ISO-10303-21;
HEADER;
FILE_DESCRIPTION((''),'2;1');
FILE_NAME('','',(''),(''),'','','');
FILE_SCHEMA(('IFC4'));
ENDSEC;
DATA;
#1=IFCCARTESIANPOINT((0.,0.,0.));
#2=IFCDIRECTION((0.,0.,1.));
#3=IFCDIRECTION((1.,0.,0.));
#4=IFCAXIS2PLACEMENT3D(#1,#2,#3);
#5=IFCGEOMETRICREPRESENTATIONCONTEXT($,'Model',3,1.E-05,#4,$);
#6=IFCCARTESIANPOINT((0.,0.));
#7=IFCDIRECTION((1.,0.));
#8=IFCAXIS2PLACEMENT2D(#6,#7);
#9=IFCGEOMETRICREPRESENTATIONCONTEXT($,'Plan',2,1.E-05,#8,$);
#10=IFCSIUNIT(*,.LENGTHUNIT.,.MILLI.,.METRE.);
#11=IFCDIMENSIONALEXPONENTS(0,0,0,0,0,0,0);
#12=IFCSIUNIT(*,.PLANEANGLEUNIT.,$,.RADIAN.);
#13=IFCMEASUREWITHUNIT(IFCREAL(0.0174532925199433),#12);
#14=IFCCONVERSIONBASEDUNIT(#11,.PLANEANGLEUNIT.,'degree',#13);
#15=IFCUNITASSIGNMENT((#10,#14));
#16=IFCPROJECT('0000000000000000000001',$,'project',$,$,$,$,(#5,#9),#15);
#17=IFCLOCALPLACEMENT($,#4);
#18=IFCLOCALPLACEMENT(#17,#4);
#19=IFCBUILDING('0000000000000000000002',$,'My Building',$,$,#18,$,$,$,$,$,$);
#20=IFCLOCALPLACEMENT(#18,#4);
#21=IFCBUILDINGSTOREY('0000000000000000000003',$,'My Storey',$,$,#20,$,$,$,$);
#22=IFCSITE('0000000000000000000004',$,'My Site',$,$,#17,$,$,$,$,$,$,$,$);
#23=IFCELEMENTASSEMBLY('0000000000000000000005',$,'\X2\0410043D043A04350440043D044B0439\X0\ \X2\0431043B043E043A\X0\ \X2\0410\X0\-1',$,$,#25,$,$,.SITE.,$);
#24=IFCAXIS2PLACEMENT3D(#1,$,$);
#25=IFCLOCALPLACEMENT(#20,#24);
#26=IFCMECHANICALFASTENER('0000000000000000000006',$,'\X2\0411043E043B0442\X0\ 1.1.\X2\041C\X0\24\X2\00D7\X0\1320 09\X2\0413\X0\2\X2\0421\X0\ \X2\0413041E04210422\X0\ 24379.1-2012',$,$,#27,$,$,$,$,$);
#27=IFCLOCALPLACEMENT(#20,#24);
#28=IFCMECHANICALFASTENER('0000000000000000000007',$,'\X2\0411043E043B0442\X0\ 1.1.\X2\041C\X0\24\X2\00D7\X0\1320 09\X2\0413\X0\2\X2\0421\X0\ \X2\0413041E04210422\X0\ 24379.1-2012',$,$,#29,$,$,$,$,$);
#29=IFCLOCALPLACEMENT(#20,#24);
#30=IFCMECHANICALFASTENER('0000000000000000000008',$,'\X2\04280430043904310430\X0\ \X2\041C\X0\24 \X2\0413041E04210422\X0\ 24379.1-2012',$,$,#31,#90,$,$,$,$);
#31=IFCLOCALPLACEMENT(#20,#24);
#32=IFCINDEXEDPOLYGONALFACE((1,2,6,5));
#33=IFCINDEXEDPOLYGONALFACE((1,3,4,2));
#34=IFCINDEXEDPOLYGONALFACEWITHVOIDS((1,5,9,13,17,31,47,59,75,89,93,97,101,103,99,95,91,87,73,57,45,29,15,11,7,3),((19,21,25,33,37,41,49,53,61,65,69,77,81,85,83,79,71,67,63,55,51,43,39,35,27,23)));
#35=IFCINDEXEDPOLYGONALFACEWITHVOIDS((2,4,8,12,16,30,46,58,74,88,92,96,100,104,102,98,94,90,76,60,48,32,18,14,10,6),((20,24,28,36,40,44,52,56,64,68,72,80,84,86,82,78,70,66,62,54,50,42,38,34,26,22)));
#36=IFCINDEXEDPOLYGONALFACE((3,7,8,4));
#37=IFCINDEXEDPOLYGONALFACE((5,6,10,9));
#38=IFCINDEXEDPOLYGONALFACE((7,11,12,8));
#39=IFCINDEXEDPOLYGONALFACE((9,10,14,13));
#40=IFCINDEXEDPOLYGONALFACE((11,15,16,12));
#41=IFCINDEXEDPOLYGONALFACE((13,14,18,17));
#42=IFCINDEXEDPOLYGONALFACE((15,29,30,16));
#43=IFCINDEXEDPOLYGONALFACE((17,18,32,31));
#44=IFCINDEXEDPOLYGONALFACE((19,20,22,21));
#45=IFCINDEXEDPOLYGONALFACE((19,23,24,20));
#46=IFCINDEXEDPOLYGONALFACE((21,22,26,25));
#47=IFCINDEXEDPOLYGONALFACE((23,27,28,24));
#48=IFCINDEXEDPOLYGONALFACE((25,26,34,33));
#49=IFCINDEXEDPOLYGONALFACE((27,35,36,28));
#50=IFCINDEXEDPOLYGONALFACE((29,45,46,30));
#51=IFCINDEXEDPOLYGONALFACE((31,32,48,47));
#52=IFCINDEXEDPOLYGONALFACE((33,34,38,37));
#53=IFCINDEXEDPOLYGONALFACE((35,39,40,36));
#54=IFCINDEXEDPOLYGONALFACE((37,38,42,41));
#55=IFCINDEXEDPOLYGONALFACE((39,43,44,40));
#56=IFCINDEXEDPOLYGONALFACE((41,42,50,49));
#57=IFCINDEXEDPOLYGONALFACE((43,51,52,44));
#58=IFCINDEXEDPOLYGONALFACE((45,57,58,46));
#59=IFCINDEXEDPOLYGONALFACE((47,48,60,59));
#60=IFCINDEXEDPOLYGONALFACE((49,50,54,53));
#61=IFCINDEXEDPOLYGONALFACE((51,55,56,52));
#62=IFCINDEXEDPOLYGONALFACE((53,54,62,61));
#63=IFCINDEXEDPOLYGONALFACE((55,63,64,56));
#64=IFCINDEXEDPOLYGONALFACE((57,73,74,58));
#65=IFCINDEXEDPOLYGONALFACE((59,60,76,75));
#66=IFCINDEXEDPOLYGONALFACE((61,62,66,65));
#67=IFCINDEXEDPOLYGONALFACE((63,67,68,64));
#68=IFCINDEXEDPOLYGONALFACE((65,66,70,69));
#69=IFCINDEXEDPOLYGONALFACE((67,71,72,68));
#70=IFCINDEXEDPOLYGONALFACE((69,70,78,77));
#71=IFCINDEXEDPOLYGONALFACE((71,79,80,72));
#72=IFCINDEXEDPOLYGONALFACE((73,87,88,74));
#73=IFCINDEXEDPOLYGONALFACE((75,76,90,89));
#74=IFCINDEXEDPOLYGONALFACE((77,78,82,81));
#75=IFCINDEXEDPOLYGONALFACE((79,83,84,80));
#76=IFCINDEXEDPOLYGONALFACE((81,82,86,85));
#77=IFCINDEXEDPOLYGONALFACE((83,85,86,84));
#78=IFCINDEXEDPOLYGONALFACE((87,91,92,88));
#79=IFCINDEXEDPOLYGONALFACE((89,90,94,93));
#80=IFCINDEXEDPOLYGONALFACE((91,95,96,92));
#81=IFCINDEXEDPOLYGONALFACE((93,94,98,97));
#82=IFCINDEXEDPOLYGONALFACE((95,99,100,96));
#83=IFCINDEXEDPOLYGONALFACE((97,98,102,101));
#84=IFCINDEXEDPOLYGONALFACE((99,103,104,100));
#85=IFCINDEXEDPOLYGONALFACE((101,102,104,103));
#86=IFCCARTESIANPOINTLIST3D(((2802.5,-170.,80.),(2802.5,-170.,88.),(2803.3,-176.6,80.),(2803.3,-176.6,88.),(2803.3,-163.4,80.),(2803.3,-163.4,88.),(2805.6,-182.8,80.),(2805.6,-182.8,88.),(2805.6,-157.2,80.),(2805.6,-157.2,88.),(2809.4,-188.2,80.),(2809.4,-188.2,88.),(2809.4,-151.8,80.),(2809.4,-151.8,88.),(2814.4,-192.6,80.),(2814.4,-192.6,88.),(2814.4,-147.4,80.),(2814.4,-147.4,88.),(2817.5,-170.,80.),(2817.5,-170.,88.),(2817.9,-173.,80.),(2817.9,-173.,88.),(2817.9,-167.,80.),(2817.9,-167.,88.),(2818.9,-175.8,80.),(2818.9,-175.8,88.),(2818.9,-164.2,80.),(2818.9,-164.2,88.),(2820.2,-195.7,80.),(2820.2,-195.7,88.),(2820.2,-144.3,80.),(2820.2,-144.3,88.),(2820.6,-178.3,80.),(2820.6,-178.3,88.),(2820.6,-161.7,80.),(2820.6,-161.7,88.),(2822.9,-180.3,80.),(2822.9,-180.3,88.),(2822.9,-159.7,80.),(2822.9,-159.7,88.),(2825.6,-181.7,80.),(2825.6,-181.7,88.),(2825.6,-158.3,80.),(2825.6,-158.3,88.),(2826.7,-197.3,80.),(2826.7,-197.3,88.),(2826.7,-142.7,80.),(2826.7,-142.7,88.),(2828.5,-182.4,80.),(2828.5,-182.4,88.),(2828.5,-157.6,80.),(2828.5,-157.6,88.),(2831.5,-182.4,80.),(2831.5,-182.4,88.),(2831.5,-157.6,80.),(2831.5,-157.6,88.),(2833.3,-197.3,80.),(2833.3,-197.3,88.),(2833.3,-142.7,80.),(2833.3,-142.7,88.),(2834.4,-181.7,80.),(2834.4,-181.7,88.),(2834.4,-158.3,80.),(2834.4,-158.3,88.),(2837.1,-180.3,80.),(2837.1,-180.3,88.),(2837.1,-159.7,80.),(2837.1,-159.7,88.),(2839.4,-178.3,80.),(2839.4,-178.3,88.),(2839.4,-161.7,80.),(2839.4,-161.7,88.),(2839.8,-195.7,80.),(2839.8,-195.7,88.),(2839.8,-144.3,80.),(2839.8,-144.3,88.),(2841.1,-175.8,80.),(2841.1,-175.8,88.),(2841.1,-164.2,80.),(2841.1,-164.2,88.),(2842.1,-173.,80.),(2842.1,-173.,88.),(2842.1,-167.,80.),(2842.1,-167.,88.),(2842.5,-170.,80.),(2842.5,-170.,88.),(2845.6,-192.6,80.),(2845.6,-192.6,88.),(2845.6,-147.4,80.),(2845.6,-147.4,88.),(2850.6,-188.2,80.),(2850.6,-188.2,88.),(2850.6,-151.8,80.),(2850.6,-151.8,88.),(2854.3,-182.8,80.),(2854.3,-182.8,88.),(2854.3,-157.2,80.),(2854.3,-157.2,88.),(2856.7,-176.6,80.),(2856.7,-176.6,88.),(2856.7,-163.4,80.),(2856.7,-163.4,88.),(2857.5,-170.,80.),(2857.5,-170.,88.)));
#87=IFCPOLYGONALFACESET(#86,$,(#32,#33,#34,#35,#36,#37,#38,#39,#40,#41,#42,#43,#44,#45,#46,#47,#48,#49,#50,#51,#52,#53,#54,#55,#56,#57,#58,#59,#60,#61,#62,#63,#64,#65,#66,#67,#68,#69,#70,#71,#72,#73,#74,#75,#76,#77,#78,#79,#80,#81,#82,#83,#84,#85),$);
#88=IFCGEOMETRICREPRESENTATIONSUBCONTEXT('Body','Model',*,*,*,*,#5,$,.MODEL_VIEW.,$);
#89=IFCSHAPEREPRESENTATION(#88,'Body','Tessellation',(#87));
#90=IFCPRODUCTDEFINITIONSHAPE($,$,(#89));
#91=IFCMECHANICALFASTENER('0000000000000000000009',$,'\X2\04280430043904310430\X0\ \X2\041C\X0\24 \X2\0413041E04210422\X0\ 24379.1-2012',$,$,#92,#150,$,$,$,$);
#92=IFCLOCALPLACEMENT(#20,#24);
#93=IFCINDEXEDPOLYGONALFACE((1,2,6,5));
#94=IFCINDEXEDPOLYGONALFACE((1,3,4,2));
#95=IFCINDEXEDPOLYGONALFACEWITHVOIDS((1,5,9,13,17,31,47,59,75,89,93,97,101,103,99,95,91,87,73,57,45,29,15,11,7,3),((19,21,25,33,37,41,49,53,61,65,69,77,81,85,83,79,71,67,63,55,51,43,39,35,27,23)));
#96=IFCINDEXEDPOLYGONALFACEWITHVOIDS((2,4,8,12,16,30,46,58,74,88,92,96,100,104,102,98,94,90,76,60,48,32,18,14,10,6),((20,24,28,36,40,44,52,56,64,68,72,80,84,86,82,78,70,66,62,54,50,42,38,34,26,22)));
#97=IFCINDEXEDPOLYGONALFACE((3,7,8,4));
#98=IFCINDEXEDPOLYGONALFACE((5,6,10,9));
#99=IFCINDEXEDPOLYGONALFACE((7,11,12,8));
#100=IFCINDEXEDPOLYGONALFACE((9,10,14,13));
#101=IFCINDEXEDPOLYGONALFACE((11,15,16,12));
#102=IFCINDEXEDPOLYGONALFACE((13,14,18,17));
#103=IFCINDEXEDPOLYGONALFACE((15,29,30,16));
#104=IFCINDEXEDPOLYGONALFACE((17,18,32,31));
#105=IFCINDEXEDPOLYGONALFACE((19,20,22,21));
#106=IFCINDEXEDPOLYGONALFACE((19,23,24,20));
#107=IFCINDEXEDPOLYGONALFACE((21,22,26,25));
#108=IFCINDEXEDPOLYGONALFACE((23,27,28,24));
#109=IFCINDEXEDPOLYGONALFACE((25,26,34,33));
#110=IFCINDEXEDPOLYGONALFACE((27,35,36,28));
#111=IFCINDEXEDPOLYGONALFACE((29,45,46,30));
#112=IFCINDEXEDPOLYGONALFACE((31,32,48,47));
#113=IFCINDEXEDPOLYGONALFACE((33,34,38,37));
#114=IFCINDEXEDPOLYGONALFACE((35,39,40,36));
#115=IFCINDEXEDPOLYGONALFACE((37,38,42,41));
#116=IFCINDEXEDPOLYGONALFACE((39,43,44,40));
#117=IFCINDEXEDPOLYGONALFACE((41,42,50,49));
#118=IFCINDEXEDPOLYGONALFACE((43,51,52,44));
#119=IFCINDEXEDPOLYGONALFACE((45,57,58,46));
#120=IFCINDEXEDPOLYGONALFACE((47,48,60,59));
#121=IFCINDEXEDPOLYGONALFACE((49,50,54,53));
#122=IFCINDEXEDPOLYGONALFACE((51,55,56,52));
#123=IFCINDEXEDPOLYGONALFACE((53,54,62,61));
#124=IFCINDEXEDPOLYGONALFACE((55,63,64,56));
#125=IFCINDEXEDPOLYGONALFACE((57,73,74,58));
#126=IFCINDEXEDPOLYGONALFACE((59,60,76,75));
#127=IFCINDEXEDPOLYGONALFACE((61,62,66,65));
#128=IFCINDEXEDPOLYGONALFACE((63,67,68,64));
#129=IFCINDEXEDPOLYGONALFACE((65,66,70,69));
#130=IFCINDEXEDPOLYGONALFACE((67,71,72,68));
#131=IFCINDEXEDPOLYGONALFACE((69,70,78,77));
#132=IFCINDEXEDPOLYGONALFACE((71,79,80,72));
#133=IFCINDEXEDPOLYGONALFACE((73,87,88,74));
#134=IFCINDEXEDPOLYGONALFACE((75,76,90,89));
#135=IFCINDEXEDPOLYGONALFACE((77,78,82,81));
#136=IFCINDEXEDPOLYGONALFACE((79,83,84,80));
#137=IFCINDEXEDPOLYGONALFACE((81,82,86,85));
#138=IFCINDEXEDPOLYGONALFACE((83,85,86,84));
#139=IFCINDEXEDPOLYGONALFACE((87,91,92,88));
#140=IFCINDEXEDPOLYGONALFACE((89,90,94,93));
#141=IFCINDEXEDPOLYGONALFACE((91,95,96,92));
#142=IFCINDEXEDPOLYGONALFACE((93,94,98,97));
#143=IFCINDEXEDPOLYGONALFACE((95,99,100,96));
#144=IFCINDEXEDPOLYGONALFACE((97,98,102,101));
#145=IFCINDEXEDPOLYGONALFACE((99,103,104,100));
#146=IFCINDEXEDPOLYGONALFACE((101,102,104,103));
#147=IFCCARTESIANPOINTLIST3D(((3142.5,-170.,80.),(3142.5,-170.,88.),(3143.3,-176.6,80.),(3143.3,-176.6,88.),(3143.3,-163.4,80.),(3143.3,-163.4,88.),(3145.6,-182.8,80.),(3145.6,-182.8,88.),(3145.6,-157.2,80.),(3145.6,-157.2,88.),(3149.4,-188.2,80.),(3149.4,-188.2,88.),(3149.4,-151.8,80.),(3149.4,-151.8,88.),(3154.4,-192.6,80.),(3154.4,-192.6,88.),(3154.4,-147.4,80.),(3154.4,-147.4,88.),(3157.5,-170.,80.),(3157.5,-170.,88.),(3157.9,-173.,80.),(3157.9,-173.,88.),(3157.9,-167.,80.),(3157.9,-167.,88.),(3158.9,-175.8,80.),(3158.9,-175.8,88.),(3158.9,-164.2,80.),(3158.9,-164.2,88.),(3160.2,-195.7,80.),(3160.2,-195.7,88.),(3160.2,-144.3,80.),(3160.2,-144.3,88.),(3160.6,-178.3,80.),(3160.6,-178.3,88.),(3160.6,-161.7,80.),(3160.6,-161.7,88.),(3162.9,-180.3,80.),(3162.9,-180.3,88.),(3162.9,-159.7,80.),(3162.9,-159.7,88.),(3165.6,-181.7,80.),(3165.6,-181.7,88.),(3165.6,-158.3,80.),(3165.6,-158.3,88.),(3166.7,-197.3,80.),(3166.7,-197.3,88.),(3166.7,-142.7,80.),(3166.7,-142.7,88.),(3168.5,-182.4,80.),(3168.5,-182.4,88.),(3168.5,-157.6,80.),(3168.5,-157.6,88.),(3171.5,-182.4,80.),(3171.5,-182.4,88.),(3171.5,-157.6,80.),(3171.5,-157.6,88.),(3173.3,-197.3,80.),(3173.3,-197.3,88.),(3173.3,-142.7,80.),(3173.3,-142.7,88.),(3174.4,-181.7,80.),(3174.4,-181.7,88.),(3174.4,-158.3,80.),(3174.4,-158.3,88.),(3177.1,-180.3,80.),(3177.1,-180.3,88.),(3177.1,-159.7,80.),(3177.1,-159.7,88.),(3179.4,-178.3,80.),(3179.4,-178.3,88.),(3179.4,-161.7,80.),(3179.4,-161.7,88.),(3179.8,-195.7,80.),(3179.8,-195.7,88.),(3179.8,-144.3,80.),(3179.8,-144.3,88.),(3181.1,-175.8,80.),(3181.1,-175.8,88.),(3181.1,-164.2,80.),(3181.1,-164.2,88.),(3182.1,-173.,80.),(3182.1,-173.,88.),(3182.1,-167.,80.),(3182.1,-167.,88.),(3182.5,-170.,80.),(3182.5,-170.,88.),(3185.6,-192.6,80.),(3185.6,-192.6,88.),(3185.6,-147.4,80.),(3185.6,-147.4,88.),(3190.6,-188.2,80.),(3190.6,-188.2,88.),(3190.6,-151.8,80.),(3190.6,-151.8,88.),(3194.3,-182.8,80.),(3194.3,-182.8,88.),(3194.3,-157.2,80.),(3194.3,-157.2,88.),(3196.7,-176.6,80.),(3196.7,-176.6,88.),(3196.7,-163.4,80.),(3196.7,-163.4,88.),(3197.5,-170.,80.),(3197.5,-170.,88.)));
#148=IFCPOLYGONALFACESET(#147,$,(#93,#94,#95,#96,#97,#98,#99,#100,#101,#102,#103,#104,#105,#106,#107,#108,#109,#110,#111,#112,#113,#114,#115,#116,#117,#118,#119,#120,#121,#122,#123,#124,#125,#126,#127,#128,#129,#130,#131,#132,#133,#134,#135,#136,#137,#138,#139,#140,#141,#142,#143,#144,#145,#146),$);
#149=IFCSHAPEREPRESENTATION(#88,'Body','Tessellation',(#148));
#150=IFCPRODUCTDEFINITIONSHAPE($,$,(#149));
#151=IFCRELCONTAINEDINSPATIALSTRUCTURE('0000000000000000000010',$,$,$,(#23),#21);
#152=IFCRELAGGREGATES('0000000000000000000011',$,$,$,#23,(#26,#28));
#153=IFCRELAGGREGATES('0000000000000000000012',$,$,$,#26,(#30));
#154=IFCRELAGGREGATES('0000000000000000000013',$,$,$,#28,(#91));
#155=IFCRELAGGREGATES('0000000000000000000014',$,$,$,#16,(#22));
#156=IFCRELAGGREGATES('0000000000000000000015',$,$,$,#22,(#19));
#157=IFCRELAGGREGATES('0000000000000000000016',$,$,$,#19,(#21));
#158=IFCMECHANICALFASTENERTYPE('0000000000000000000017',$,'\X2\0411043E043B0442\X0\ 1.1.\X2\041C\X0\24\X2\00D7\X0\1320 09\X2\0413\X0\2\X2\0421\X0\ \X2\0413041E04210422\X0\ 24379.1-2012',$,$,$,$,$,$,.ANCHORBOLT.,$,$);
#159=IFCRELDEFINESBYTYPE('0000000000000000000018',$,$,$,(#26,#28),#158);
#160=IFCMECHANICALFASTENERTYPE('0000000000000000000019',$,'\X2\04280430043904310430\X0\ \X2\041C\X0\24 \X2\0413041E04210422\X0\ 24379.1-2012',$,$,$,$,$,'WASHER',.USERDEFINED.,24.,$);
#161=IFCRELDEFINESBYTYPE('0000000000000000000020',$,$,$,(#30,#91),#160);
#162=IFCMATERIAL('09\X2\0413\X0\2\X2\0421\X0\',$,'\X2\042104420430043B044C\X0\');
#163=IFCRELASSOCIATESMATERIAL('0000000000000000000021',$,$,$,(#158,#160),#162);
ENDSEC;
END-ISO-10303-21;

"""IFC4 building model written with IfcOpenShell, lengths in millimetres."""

from ifc_helpers import new_model, entity, si_unit, converted_unit, frame, origin_with_axes, origin_2d_with_axis, place, context, subcontext, project, spatial, polyline, outline, extrude, source, transform, mapped, material, type_object, type_shapes, element, aggregate, save


model = new_model("IFC4")

# Units and contexts
model_context = context("Model", 3, precision=1e-05, world=origin_with_axes())
plan_context = context("Plan", 2, precision=1e-05, world=origin_2d_with_axis())
body_context = subcontext(model_context, "Body", "Model", "MODEL_VIEW")
ifc_project = project(units=[si_unit("LENGTHUNIT", "METRE", prefix="MILLI"), converted_unit("PLANEANGLEUNIT", "degree", entity("IfcReal", 0.0174532925199433), si_unit("PLANEANGLEUNIT", "RADIAN"), dimensions=[0, 0, 0, 0, 0, 0, 0])], contexts=[model_context, plan_context])

# Site, building, storey
site_placement = place(None, origin_with_axes())
site = spatial("IfcSite", under=ifc_project, at=site_placement, Name="My Site")
building_placement = place(site_placement, origin_with_axes())
building = spatial("IfcBuilding", under=site, at=building_placement, Name="My Building")
storey_placement = place(building_placement, origin_with_axes())
storey = spatial("IfcBuildingStorey", under=building, at=storey_placement, Name="My Storey")

# Element assembly
placement_1 = place(storey_placement, frame((3000.0, 0.0, 0.0), z_axis=(0.0, 0.0, 1.0), x_axis=(1.0, 0.0, 0.0)))
assembly_1 = element("IfcElementAssembly", 1, at=placement_1, inside=storey, Name="Анкерный блок А-1", AssemblyPlace="SITE")

# Shared definitions
ifc_material_1 = material(Name="09Г2С", Category="Сталь")
mechanical_fastener_type_1 = type_object("IfcMechanicalFastenerType", Name="Болт 1.1.М24×1320 09Г2С ГОСТ 24379.1-2012", PredefinedType="ANCHORBOLT", material=ifc_material_1)

# Mechanical fasteners
mechanical_fastener_1_placement = place(placement_1, frame((-170.0, -170.0, 0.0), z_axis=(0.0, 0.0, 1.0), x_axis=(1.0, 0.0, 0.0)))
mechanical_fastener_1 = element("IfcMechanicalFastener", 2, at=mechanical_fastener_1_placement, type_object=mechanical_fastener_type_1, Name="Болт 1.1.М24×1320 09Г2С ГОСТ 24379.1-2012")
mechanical_fastener_2_placement = place(placement_1, frame((170.0, -170.0, 0.0), z_axis=(0.0, 0.0, 1.0), x_axis=(1.0, 0.0, 0.0)))
mechanical_fastener_2 = element("IfcMechanicalFastener", 3, at=mechanical_fastener_2_placement, type_object=mechanical_fastener_type_1, Name="Болт 1.1.М24×1320 09Г2С ГОСТ 24379.1-2012")

# Mechanical fasteners
aggregate(assembly_1, [mechanical_fastener_1, mechanical_fastener_2])
mechanical_fastener_type_2 = type_object("IfcMechanicalFastenerType", Name="Шайба М24 ГОСТ 24379.1-2012", ElementType="WASHER", NominalDiameter=24.0, PredefinedType="USERDEFINED", material=ifc_material_1)
shared_shape_1 = source(origin_with_axes(), body_context, "Body", "SweptSolid", [
    extrude(outline(polyline([(27.5, 0.0), (26.7, 6.6), (24.4, 12.8), (20.6, 18.2), (15.6, 22.6), (9.8, 25.7), (3.3, 27.3), (-3.3, 27.3), (-9.8, 25.7), (-15.6, 22.6), (-20.6, 18.2), (-24.4, 12.8), (-26.7, 6.6), (-27.5, 0.0), (-26.7, -6.6), (-24.4, -12.8), (-20.6, -18.2), (-15.6, -22.6), (-9.8, -25.7), (-3.3, -27.3), (3.3, -27.3), (9.8, -25.7), (15.6, -22.6), (20.6, -18.2), (24.4, -12.8), (26.7, -6.6), (27.5, 0.0)]), holes=[polyline([(-4.4, -11.7), (-7.1, -10.3), (-9.4, -8.3), (-11.1, -5.8), (-12.1, -3.0), (-12.5, 0.0), (-12.1, 3.0), (-11.1, 5.8), (-9.4, 8.3), (-7.1, 10.3), (-4.4, 11.7), (-1.5, 12.4), (1.5, 12.4), (4.4, 11.7), (7.1, 10.3), (9.4, 8.3), (11.1, 5.8), (12.1, 3.0), (12.5, 0.0), (12.1, -3.0), (11.1, -5.8), (9.4, -8.3), (7.1, -10.3), (4.4, -11.7), (1.5, -12.4), (-1.5, -12.4), (-4.4, -11.7)])]), frame((0.0, 0.0, 0.0), z_axis=(0.0, 0.0, 1.0), x_axis=(0.120537, -0.992709, 0.0)), (0.0, 0.0, 1.0), 8.0),
])
type_shapes(mechanical_fastener_type_2, [shared_shape_1])
mechanical_fastener_3_placement = place(mechanical_fastener_1_placement, frame((0.0, 0.0, 80.0), z_axis=(0.0, 0.0, 1.0), x_axis=(1.0, 0.0, 0.0)))
mechanical_fastener_3 = element("IfcMechanicalFastener", 4, at=mechanical_fastener_3_placement, type_object=mechanical_fastener_type_2, Name="Шайба М24 ГОСТ 24379.1-2012", context=body_context, shape_type="MappedRepresentation", body=[
    mapped(shared_shape_1, transform((0.0, 0.0, 0.0), x_axis=(1.0, 0.0, 0.0), y_axis=(0.0, 1.0, 0.0), z_axis=(0.0, 0.0, 1.0), scale=1.0)),
])
aggregate(mechanical_fastener_1, [mechanical_fastener_3])
mechanical_fastener_4_placement = place(mechanical_fastener_2_placement, frame((0.0, 0.0, 80.0), z_axis=(0.0, 0.0, 1.0), x_axis=(1.0, 0.0, 0.0)))
mechanical_fastener_4 = element("IfcMechanicalFastener", 5, at=mechanical_fastener_4_placement, type_object=mechanical_fastener_type_2, Name="Шайба М24 ГОСТ 24379.1-2012", context=body_context, shape_type="MappedRepresentation", body=[
    mapped(shared_shape_1, transform((0.0, 0.0, 0.0), x_axis=(1.0, 0.0, 0.0), y_axis=(0.0, 1.0, 0.0), z_axis=(0.0, 0.0, 1.0), scale=1.0)),
])
aggregate(mechanical_fastener_2, [mechanical_fastener_4])

save(model, "model.ifc")
